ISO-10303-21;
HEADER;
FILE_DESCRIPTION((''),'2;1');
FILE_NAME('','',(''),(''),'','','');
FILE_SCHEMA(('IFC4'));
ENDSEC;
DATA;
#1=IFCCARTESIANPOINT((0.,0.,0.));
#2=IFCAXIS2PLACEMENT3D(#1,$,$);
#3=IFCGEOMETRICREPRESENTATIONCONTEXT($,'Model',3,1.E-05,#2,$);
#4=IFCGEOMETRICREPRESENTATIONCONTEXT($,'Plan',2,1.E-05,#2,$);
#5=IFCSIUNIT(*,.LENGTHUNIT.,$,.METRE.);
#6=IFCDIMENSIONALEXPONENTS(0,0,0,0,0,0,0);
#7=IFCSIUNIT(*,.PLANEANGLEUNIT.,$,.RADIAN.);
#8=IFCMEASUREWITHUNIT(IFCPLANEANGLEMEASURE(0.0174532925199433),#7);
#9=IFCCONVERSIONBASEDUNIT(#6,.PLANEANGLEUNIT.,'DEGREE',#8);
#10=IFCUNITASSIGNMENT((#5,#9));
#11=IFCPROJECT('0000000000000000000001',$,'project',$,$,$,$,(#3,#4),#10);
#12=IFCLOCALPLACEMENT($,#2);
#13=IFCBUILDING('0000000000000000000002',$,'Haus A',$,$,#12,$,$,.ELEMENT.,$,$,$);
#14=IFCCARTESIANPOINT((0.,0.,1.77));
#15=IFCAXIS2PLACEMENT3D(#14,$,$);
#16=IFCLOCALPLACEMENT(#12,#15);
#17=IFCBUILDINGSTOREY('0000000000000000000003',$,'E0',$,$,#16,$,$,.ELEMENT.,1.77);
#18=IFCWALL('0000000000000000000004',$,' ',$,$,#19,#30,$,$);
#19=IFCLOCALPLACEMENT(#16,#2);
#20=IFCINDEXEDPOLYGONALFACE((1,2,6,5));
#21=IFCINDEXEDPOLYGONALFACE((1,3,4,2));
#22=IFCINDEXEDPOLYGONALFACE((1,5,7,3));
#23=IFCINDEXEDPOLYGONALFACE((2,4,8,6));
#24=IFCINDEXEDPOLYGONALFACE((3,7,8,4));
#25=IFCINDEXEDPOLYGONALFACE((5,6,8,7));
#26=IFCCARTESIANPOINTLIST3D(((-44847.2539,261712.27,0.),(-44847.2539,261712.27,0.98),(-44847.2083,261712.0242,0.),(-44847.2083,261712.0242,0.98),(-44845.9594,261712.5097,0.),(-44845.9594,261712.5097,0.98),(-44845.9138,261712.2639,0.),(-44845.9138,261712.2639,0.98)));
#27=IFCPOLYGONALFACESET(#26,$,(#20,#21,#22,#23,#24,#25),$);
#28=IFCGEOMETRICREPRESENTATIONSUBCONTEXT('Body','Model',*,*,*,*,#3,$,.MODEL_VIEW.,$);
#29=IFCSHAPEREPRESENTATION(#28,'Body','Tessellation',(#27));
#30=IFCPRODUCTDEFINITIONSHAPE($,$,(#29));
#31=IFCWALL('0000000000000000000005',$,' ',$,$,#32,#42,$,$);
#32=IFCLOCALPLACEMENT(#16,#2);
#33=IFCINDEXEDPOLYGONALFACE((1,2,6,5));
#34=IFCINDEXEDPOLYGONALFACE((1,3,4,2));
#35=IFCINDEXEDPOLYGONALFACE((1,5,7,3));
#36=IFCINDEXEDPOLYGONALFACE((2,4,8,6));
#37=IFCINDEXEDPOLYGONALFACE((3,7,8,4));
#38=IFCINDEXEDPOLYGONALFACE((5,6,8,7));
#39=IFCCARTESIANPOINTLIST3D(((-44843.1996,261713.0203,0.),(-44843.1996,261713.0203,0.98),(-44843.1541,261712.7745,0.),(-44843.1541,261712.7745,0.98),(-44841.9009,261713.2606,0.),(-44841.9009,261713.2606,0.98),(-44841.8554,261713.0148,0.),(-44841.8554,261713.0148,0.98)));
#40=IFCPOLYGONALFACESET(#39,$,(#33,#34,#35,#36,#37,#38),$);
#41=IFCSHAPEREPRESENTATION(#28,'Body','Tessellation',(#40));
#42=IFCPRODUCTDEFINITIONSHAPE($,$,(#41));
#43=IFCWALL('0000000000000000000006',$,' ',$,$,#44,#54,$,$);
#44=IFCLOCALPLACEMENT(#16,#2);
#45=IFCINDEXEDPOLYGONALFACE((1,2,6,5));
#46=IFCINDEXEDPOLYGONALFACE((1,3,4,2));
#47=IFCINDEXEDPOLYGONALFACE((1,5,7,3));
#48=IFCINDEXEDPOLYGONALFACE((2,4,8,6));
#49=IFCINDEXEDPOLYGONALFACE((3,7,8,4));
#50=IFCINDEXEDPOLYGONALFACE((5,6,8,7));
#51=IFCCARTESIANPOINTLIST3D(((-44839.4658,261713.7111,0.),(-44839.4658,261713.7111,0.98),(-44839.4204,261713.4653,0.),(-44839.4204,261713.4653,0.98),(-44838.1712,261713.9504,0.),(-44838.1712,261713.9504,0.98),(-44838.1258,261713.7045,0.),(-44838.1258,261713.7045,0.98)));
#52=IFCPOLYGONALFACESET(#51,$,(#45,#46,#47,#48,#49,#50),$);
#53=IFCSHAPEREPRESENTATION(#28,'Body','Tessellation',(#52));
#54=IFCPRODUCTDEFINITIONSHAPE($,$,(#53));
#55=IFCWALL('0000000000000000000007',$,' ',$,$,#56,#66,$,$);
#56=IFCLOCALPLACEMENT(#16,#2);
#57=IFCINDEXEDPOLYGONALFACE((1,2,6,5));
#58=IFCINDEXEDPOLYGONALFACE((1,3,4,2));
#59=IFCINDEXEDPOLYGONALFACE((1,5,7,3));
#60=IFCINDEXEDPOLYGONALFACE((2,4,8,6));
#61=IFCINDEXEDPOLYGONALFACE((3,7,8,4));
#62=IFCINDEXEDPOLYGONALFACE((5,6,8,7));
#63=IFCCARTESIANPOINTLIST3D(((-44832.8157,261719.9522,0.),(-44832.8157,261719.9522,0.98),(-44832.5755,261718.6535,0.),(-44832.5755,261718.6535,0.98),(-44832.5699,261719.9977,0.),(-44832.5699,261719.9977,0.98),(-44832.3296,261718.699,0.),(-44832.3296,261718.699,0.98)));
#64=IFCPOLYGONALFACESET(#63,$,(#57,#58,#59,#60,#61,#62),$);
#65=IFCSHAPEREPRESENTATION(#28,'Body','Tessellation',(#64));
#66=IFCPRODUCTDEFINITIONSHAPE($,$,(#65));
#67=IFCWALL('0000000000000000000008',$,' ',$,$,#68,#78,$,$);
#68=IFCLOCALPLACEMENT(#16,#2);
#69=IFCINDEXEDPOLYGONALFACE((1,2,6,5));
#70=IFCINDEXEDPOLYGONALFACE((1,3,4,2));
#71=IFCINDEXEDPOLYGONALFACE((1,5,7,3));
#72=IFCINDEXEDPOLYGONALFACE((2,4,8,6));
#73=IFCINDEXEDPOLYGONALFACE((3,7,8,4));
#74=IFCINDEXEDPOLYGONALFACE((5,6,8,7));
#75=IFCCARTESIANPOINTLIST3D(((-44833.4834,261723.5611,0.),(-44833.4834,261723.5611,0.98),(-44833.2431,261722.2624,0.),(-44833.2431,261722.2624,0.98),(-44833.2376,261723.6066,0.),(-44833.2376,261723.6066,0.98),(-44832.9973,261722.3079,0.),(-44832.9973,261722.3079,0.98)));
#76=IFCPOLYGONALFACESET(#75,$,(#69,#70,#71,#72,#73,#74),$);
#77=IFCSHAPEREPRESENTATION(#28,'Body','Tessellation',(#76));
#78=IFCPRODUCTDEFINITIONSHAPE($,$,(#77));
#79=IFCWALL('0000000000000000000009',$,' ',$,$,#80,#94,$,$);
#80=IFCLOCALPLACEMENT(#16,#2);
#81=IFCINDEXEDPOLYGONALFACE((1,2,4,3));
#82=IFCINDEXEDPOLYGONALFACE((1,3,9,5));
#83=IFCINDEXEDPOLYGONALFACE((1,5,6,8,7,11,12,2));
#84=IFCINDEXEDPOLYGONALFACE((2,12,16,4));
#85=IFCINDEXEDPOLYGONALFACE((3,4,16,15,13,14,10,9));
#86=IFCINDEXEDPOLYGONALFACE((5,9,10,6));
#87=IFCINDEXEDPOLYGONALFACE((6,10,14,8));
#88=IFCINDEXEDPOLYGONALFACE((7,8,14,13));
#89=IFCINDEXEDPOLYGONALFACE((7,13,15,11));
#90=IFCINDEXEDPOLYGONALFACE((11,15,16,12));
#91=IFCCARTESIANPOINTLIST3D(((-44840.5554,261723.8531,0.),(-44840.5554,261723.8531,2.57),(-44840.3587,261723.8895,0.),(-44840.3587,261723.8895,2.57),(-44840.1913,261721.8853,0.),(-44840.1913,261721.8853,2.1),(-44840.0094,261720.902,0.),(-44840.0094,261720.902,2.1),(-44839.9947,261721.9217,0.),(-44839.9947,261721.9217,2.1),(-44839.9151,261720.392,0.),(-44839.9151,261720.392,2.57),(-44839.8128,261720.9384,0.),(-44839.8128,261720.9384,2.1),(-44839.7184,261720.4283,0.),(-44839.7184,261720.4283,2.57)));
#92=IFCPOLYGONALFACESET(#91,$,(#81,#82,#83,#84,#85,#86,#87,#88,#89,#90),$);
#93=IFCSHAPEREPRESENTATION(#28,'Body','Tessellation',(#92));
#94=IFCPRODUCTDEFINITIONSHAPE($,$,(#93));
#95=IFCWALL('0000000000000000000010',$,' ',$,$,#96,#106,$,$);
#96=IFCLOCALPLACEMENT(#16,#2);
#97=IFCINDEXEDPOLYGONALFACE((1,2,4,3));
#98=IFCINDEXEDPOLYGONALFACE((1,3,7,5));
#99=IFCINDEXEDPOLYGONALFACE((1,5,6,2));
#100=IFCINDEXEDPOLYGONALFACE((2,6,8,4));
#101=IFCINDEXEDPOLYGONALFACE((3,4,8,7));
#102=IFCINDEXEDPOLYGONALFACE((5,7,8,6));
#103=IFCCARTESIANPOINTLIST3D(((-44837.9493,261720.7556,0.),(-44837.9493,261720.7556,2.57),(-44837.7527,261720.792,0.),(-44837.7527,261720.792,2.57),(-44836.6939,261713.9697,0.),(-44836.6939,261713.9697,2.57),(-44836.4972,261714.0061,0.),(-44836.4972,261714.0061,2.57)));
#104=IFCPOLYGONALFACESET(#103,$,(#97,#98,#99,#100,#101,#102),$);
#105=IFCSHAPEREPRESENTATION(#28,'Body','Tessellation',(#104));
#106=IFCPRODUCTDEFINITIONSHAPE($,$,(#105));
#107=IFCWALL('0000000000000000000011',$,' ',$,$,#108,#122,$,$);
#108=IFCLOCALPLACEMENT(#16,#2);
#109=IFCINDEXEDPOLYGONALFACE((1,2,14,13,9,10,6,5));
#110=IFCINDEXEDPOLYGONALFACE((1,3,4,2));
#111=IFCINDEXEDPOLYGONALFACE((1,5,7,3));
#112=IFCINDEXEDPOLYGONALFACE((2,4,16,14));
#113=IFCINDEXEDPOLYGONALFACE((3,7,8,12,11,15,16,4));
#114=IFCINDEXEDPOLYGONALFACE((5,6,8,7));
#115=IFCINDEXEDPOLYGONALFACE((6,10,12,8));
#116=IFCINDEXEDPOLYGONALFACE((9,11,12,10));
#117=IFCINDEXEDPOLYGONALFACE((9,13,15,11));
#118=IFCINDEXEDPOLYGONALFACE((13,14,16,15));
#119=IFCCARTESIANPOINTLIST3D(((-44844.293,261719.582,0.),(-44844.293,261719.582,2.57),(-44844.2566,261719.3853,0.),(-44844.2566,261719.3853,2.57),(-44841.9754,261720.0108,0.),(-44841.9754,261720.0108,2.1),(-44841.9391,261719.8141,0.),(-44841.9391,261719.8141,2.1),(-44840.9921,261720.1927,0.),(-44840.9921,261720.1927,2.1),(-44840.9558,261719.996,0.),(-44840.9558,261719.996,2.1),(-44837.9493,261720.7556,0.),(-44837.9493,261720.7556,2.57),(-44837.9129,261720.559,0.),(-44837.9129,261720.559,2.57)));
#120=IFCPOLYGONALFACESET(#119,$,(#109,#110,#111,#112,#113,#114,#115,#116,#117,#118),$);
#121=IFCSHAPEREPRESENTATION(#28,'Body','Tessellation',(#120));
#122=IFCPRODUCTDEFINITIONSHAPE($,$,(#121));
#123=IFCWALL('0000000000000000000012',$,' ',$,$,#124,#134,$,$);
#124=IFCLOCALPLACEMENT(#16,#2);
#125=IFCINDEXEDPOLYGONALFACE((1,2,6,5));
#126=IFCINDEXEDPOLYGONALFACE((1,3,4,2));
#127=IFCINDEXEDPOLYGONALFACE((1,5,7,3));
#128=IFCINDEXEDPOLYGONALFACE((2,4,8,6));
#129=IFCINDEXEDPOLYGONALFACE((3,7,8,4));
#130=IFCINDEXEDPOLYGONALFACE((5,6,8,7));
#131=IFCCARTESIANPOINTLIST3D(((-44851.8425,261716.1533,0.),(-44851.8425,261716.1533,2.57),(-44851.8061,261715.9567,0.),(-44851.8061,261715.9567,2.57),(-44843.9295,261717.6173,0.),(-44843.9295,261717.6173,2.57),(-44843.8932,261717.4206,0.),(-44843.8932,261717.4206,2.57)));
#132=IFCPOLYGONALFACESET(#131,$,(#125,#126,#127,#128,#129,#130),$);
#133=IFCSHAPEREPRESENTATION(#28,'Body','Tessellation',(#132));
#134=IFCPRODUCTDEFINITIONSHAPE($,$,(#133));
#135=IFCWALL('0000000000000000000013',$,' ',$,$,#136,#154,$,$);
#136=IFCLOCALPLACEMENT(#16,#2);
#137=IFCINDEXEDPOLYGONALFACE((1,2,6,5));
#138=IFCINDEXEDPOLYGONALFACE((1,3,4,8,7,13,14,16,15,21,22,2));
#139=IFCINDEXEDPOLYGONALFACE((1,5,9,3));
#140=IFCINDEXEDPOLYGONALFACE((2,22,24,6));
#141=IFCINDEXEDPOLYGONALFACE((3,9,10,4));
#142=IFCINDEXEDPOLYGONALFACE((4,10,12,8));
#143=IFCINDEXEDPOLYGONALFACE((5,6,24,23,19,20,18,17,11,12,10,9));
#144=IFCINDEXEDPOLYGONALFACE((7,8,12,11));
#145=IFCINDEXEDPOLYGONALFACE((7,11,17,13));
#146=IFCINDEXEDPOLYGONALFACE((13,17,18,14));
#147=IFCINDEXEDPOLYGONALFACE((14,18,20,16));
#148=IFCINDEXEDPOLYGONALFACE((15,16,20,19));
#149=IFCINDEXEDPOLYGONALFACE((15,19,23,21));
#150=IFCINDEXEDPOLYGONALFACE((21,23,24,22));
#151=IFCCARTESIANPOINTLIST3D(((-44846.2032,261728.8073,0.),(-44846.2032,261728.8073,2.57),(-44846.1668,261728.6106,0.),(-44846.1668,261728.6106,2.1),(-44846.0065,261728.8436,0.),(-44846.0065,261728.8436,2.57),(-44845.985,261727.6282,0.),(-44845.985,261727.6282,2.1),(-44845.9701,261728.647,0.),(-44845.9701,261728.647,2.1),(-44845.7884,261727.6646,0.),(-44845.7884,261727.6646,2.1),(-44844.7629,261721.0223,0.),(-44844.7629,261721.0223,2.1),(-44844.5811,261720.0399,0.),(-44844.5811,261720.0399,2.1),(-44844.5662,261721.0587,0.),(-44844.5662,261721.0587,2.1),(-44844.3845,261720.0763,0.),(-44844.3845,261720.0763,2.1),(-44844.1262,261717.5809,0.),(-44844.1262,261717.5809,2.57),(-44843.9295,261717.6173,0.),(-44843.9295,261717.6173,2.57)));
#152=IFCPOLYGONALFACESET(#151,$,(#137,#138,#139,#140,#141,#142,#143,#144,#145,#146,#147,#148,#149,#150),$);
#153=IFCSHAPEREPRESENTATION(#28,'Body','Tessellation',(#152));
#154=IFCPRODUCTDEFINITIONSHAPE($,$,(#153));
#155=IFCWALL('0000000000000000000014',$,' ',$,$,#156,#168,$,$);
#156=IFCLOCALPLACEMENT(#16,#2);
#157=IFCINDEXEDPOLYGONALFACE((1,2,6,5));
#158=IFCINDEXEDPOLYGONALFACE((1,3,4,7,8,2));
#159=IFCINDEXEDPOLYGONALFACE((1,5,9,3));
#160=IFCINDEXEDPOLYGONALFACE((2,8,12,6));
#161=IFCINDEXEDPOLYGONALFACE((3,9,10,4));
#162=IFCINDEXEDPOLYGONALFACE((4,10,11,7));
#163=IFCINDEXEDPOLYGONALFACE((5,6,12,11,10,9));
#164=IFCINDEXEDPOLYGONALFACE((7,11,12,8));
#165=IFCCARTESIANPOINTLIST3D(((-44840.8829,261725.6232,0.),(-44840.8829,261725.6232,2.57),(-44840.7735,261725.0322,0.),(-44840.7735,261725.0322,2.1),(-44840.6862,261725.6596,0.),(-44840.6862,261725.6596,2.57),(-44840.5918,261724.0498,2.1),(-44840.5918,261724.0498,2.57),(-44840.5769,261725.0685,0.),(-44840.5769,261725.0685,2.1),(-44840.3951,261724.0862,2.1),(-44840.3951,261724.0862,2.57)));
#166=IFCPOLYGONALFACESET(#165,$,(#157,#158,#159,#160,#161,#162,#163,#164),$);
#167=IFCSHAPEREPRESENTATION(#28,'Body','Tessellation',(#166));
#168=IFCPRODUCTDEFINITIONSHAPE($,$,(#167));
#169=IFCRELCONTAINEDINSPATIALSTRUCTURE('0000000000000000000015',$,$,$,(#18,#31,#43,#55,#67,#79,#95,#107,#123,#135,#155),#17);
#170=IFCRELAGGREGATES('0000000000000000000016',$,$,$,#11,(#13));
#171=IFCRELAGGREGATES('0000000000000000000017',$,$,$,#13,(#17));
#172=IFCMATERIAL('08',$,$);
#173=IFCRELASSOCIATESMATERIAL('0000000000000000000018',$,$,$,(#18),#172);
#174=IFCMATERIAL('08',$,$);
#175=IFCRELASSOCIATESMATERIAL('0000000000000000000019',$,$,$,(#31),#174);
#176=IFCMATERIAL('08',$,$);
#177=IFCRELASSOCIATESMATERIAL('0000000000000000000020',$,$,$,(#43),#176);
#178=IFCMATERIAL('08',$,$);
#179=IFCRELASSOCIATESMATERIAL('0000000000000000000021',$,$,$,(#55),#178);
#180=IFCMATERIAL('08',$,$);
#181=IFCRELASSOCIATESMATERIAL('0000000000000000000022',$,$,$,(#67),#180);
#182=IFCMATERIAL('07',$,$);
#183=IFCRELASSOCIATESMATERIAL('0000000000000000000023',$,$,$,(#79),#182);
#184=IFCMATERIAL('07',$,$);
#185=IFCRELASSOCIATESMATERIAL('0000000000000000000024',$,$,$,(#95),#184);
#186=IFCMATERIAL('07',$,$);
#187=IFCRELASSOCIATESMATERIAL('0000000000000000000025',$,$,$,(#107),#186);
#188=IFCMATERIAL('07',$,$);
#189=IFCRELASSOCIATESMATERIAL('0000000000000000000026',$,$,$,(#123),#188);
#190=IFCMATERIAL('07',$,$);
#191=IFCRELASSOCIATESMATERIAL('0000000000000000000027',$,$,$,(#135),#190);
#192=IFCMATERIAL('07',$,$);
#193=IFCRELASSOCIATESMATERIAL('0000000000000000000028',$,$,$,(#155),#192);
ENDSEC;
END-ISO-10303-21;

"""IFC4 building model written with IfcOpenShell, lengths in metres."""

from ifc_helpers import new_model, entity, si_unit, converted_unit, frame, frame_2d, origin, origin_with_axes, place, context, subcontext, project, spatial, polyline, rectangle, outline, extrude, material, element, save


model = new_model("IFC4")

# Units and contexts
model_context = context("Model", 3, precision=1e-05, world=origin())
plan_context = context("Plan", 2, precision=1e-05, world=origin())
body_context = subcontext(model_context, "Body", "Model", "MODEL_VIEW")
ifc_project = project(units=[si_unit("LENGTHUNIT", "METRE"), converted_unit("PLANEANGLEUNIT", "DEGREE", entity("IfcPlaneAngleMeasure", 0.0174532925199433), si_unit("PLANEANGLEUNIT", "RADIAN"), dimensions=[0, 0, 0, 0, 0, 0, 0])], contexts=[model_context, plan_context])

# Building, storey
building_placement = place(None, origin())
building = spatial("IfcBuilding", under=ifc_project, at=building_placement, Name="Haus A", CompositionType="ELEMENT")
storey_placement = place(building_placement, frame((0.0, 0.0, 1.77)))
storey = spatial("IfcBuildingStorey", under=building, at=storey_placement, Name="E0", CompositionType="ELEMENT", Elevation=1.77)

# Walls
ifc_material_1 = material(Name="08")
wall_1_placement = place(storey_placement, frame((-44845.9594, 261712.5097, 0.0), z_axis=(0.0, 0.0, 1.0), x_axis=(-0.98328, -0.182101, 0.0)))
element("IfcWall", 1, at=wall_1_placement, inside=storey, material=ifc_material_1, Name=" ", context=body_context, shape_type="SweptSolid", body=[
    extrude(rectangle(XDim=1.3165, YDim=0.25, at=frame_2d((0.6583, 0.125), x_axis=(1.0, 0.0))), origin_with_axes(), (0.0, 0.0, 1.0), 0.98),
])
ifc_material_2 = material(Name="08")
wall_2_placement = place(storey_placement, frame((-44841.9009, 261713.2606, 0.0), z_axis=(0.0, 0.0, 1.0), x_axis=(-0.983313, -0.18192, 0.0)))
element("IfcWall", 2, at=wall_2_placement, inside=storey, material=ifc_material_2, Name=" ", context=body_context, shape_type="SweptSolid", body=[
    extrude(rectangle(XDim=1.3207, YDim=0.25, at=frame_2d((0.6604, 0.125), x_axis=(1.0, 0.0))), origin_with_axes(), (0.0, 0.0, 1.0), 0.98),
])
ifc_material_3 = material(Name="08")
wall_3_placement = place(storey_placement, frame((-44838.1712, 261713.9504, 0.0), z_axis=(0.0, 0.0, 1.0), x_axis=(-0.983347, -0.181738, 0.0)))
element("IfcWall", 3, at=wall_3_placement, inside=storey, material=ifc_material_3, Name=" ", context=body_context, shape_type="SweptSolid", body=[
    extrude(rectangle(XDim=1.3165, YDim=0.25, at=frame_2d((0.6583, 0.125), x_axis=(1.0, 0.0))), origin_with_axes(), (0.0, 0.0, 1.0), 0.98),
])
ifc_material_4 = material(Name="08")
wall_4_placement = place(storey_placement, frame((-44832.3296, 261718.699, 0.0), z_axis=(0.0, 0.0, 1.0), x_axis=(-0.18192, 0.983313, 0.0)))
element("IfcWall", 4, at=wall_4_placement, inside=storey, material=ifc_material_4, Name=" ", context=body_context, shape_type="SweptSolid", body=[
    extrude(rectangle(XDim=1.3207, YDim=0.25, at=frame_2d((0.6604, 0.125), x_axis=(1.0, 0.0))), origin_with_axes(), (0.0, 0.0, 1.0), 0.98),
])
ifc_material_5 = material(Name="08")
wall_5_placement = place(storey_placement, frame((-44832.9973, 261722.3079, 0.0), z_axis=(0.0, 0.0, 1.0), x_axis=(-0.18192, 0.983313, 0.0)))
element("IfcWall", 5, at=wall_5_placement, inside=storey, material=ifc_material_5, Name=" ", context=body_context, shape_type="SweptSolid", body=[
    extrude(rectangle(XDim=1.3207, YDim=0.25, at=frame_2d((0.6604, 0.125), x_axis=(1.0, 0.0))), origin_with_axes(), (0.0, 0.0, 1.0), 0.98),
])

# Wall, opening
ifc_material_6 = material(Name="07")
wall_6_placement = place(storey_placement, frame((-44839.7184, 261720.4283, 0.0), z_axis=(0.0, 0.0, 1.0), x_axis=(-0.18192, 0.983313, 0.0)))
wall_6 = element("IfcWall", 6, at=wall_6_placement, inside=storey, material=ifc_material_6, Name=" ", context=body_context, shape_type="SweptSolid", body=[
    extrude(rectangle(XDim=3.5199, YDim=0.2, at=frame_2d((1.76, 0.1), x_axis=(1.0, 0.0))), origin_with_axes(), (0.0, 0.0, 1.0), 2.57),
])
opening_1_placement = place(wall_6_placement, frame((0.5187, 0.0, 0.0), z_axis=(0.0, 1.0, 0.0), x_axis=(0.0, 0.0, 1.0)))
element("IfcOpeningElement", 7, at=opening_1_placement, cuts=wall_6, ObjectType="Opening", context=body_context, shape_type="SweptSolid", body=[
    extrude(outline(polyline([(0.0, 1.0), (2.1, 1.0), (2.1, 0.0), (0.0, 0.0), (0.0, 1.0)])), origin_with_axes(), (0.0, 0.0, 1.0), 0.2),
])

# Wall
ifc_material_7 = material(Name="07")
wall_7_placement = place(storey_placement, frame((-44837.9493, 261720.7556, 0.0), z_axis=(0.0, 0.0, 1.0), x_axis=(0.18192, -0.983313, 0.0)))
element("IfcWall", 8, at=wall_7_placement, inside=storey, material=ifc_material_7, Name=" ", context=body_context, shape_type="SweptSolid", body=[
    extrude(rectangle(XDim=6.9011, YDim=0.2, at=frame_2d((3.4506, 0.1), x_axis=(1.0, 0.0))), origin_with_axes(), (0.0, 0.0, 1.0), 2.57),
])

# Wall, opening
ifc_material_8 = material(Name="07")
wall_8_placement = place(storey_placement, frame((-44844.2566, 261719.3853, 0.0), z_axis=(0.0, 0.0, 1.0), x_axis=(0.983313, 0.18192, 0.0)))
wall_8 = element("IfcWall", 9, at=wall_8_placement, inside=storey, material=ifc_material_8, Name=" ", context=body_context, shape_type="SweptSolid", body=[
    extrude(rectangle(XDim=6.4514, YDim=0.2, at=frame_2d((3.2257, 0.1), x_axis=(1.0, 0.0))), origin_with_axes(), (0.0, 0.0, 1.0), 2.57),
])
opening_2_placement = place(wall_8_placement, frame((2.3569, 0.0, 0.0), z_axis=(0.0, 1.0, 0.0), x_axis=(0.0, 0.0, 1.0)))
element("IfcOpeningElement", 10, at=opening_2_placement, cuts=wall_8, ObjectType="Opening", context=body_context, shape_type="SweptSolid", body=[
    extrude(outline(polyline([(0.0, 1.0), (2.1, 1.0), (2.1, 0.0), (0.0, 0.0), (0.0, 1.0)])), origin_with_axes(), (0.0, 0.0, 1.0), 0.2),
])

# Wall
ifc_material_9 = material(Name="07")
wall_9_placement = place(storey_placement, frame((-44851.8061, 261715.9567, 0.0), z_axis=(0.0, 0.0, 1.0), x_axis=(0.983313, 0.18192, 0.0)))
element("IfcWall", 11, at=wall_9_placement, inside=storey, material=ifc_material_9, Name=" ", context=body_context, shape_type="SweptSolid", body=[
    extrude(rectangle(XDim=8.0473, YDim=0.2, at=frame_2d((4.0236, 0.1), x_axis=(1.0, 0.0))), origin_with_axes(), (0.0, 0.0, 1.0), 2.57),
])

# Wall, openings
ifc_material_10 = material(Name="07")
wall_10_placement = place(storey_placement, frame((-44843.9295, 261717.6173, 0.0), z_axis=(0.0, 0.0, 1.0), x_axis=(-0.18192, 0.983313, 0.0)))
wall_10 = element("IfcWall", 12, at=wall_10_placement, inside=storey, material=ifc_material_10, Name=" ", context=body_context, shape_type="SweptSolid", body=[
    extrude(rectangle(XDim=11.4169, YDim=0.2, at=frame_2d((5.7084, 0.1), x_axis=(1.0, 0.0))), origin_with_axes(), (0.0, 0.0, 1.0), 2.57),
])
opening_3_placement = place(wall_10_placement, frame((2.5008, 0.0, 0.0), z_axis=(0.0, 1.0, 0.0), x_axis=(0.0, 0.0, 1.0)))
element("IfcOpeningElement", 13, at=opening_3_placement, cuts=wall_10, ObjectType="Opening", context=body_context, shape_type="SweptSolid", body=[
    extrude(outline(polyline([(0.0, 0.999), (2.1, 0.999), (2.1, 0.0), (0.0, 0.0), (0.0, 0.999)])), origin_with_axes(), (0.0, 0.0, 1.0), 0.2),
])
opening_4_placement = place(wall_10_placement, frame((10.2178, 0.0, 0.0), z_axis=(0.0, 1.0, 0.0), x_axis=(0.0, 0.0, 1.0)))
element("IfcOpeningElement", 14, at=opening_4_placement, cuts=wall_10, ObjectType="Opening", context=body_context, shape_type="SweptSolid", body=[
    extrude(outline(polyline([(0.0, 0.999), (2.1, 0.999), (2.1, 0.0), (0.0, 0.0), (0.0, 0.999)])), origin_with_axes(), (0.0, 0.0, 1.0), 0.2),
])

# Wall, opening
ifc_material_11 = material(Name="07")
wall_11_placement = place(storey_placement, frame((-44840.3951, 261724.0862, 0.0), z_axis=(0.0, 0.0, 1.0), x_axis=(-0.18192, 0.983313, 0.0)))
wall_11 = element("IfcWall", 15, at=wall_11_placement, inside=storey, material=ifc_material_11, Name=" ", context=body_context, shape_type="SweptSolid", body=[
    extrude(rectangle(XDim=1.6001, YDim=0.2, at=frame_2d((0.8001, 0.1), x_axis=(1.0, 0.0))), origin_with_axes(), (0.0, 0.0, 1.0), 2.57),
])
opening_5_placement = place(wall_11_placement, frame((0.0, 0.0, 0.0), z_axis=(0.0, 1.0, 0.0), x_axis=(0.0, 0.0, 1.0)))
element("IfcOpeningElement", 16, at=opening_5_placement, cuts=wall_11, ObjectType="Opening", context=body_context, shape_type="SweptSolid", body=[
    extrude(outline(polyline([(0.0, 0.999), (2.1, 0.999), (2.1, 0.0), (0.0, 0.0), (0.0, 0.999)])), origin_with_axes(), (0.0, 0.0, 1.0), 0.2),
])

save(model, "model.ifc")
